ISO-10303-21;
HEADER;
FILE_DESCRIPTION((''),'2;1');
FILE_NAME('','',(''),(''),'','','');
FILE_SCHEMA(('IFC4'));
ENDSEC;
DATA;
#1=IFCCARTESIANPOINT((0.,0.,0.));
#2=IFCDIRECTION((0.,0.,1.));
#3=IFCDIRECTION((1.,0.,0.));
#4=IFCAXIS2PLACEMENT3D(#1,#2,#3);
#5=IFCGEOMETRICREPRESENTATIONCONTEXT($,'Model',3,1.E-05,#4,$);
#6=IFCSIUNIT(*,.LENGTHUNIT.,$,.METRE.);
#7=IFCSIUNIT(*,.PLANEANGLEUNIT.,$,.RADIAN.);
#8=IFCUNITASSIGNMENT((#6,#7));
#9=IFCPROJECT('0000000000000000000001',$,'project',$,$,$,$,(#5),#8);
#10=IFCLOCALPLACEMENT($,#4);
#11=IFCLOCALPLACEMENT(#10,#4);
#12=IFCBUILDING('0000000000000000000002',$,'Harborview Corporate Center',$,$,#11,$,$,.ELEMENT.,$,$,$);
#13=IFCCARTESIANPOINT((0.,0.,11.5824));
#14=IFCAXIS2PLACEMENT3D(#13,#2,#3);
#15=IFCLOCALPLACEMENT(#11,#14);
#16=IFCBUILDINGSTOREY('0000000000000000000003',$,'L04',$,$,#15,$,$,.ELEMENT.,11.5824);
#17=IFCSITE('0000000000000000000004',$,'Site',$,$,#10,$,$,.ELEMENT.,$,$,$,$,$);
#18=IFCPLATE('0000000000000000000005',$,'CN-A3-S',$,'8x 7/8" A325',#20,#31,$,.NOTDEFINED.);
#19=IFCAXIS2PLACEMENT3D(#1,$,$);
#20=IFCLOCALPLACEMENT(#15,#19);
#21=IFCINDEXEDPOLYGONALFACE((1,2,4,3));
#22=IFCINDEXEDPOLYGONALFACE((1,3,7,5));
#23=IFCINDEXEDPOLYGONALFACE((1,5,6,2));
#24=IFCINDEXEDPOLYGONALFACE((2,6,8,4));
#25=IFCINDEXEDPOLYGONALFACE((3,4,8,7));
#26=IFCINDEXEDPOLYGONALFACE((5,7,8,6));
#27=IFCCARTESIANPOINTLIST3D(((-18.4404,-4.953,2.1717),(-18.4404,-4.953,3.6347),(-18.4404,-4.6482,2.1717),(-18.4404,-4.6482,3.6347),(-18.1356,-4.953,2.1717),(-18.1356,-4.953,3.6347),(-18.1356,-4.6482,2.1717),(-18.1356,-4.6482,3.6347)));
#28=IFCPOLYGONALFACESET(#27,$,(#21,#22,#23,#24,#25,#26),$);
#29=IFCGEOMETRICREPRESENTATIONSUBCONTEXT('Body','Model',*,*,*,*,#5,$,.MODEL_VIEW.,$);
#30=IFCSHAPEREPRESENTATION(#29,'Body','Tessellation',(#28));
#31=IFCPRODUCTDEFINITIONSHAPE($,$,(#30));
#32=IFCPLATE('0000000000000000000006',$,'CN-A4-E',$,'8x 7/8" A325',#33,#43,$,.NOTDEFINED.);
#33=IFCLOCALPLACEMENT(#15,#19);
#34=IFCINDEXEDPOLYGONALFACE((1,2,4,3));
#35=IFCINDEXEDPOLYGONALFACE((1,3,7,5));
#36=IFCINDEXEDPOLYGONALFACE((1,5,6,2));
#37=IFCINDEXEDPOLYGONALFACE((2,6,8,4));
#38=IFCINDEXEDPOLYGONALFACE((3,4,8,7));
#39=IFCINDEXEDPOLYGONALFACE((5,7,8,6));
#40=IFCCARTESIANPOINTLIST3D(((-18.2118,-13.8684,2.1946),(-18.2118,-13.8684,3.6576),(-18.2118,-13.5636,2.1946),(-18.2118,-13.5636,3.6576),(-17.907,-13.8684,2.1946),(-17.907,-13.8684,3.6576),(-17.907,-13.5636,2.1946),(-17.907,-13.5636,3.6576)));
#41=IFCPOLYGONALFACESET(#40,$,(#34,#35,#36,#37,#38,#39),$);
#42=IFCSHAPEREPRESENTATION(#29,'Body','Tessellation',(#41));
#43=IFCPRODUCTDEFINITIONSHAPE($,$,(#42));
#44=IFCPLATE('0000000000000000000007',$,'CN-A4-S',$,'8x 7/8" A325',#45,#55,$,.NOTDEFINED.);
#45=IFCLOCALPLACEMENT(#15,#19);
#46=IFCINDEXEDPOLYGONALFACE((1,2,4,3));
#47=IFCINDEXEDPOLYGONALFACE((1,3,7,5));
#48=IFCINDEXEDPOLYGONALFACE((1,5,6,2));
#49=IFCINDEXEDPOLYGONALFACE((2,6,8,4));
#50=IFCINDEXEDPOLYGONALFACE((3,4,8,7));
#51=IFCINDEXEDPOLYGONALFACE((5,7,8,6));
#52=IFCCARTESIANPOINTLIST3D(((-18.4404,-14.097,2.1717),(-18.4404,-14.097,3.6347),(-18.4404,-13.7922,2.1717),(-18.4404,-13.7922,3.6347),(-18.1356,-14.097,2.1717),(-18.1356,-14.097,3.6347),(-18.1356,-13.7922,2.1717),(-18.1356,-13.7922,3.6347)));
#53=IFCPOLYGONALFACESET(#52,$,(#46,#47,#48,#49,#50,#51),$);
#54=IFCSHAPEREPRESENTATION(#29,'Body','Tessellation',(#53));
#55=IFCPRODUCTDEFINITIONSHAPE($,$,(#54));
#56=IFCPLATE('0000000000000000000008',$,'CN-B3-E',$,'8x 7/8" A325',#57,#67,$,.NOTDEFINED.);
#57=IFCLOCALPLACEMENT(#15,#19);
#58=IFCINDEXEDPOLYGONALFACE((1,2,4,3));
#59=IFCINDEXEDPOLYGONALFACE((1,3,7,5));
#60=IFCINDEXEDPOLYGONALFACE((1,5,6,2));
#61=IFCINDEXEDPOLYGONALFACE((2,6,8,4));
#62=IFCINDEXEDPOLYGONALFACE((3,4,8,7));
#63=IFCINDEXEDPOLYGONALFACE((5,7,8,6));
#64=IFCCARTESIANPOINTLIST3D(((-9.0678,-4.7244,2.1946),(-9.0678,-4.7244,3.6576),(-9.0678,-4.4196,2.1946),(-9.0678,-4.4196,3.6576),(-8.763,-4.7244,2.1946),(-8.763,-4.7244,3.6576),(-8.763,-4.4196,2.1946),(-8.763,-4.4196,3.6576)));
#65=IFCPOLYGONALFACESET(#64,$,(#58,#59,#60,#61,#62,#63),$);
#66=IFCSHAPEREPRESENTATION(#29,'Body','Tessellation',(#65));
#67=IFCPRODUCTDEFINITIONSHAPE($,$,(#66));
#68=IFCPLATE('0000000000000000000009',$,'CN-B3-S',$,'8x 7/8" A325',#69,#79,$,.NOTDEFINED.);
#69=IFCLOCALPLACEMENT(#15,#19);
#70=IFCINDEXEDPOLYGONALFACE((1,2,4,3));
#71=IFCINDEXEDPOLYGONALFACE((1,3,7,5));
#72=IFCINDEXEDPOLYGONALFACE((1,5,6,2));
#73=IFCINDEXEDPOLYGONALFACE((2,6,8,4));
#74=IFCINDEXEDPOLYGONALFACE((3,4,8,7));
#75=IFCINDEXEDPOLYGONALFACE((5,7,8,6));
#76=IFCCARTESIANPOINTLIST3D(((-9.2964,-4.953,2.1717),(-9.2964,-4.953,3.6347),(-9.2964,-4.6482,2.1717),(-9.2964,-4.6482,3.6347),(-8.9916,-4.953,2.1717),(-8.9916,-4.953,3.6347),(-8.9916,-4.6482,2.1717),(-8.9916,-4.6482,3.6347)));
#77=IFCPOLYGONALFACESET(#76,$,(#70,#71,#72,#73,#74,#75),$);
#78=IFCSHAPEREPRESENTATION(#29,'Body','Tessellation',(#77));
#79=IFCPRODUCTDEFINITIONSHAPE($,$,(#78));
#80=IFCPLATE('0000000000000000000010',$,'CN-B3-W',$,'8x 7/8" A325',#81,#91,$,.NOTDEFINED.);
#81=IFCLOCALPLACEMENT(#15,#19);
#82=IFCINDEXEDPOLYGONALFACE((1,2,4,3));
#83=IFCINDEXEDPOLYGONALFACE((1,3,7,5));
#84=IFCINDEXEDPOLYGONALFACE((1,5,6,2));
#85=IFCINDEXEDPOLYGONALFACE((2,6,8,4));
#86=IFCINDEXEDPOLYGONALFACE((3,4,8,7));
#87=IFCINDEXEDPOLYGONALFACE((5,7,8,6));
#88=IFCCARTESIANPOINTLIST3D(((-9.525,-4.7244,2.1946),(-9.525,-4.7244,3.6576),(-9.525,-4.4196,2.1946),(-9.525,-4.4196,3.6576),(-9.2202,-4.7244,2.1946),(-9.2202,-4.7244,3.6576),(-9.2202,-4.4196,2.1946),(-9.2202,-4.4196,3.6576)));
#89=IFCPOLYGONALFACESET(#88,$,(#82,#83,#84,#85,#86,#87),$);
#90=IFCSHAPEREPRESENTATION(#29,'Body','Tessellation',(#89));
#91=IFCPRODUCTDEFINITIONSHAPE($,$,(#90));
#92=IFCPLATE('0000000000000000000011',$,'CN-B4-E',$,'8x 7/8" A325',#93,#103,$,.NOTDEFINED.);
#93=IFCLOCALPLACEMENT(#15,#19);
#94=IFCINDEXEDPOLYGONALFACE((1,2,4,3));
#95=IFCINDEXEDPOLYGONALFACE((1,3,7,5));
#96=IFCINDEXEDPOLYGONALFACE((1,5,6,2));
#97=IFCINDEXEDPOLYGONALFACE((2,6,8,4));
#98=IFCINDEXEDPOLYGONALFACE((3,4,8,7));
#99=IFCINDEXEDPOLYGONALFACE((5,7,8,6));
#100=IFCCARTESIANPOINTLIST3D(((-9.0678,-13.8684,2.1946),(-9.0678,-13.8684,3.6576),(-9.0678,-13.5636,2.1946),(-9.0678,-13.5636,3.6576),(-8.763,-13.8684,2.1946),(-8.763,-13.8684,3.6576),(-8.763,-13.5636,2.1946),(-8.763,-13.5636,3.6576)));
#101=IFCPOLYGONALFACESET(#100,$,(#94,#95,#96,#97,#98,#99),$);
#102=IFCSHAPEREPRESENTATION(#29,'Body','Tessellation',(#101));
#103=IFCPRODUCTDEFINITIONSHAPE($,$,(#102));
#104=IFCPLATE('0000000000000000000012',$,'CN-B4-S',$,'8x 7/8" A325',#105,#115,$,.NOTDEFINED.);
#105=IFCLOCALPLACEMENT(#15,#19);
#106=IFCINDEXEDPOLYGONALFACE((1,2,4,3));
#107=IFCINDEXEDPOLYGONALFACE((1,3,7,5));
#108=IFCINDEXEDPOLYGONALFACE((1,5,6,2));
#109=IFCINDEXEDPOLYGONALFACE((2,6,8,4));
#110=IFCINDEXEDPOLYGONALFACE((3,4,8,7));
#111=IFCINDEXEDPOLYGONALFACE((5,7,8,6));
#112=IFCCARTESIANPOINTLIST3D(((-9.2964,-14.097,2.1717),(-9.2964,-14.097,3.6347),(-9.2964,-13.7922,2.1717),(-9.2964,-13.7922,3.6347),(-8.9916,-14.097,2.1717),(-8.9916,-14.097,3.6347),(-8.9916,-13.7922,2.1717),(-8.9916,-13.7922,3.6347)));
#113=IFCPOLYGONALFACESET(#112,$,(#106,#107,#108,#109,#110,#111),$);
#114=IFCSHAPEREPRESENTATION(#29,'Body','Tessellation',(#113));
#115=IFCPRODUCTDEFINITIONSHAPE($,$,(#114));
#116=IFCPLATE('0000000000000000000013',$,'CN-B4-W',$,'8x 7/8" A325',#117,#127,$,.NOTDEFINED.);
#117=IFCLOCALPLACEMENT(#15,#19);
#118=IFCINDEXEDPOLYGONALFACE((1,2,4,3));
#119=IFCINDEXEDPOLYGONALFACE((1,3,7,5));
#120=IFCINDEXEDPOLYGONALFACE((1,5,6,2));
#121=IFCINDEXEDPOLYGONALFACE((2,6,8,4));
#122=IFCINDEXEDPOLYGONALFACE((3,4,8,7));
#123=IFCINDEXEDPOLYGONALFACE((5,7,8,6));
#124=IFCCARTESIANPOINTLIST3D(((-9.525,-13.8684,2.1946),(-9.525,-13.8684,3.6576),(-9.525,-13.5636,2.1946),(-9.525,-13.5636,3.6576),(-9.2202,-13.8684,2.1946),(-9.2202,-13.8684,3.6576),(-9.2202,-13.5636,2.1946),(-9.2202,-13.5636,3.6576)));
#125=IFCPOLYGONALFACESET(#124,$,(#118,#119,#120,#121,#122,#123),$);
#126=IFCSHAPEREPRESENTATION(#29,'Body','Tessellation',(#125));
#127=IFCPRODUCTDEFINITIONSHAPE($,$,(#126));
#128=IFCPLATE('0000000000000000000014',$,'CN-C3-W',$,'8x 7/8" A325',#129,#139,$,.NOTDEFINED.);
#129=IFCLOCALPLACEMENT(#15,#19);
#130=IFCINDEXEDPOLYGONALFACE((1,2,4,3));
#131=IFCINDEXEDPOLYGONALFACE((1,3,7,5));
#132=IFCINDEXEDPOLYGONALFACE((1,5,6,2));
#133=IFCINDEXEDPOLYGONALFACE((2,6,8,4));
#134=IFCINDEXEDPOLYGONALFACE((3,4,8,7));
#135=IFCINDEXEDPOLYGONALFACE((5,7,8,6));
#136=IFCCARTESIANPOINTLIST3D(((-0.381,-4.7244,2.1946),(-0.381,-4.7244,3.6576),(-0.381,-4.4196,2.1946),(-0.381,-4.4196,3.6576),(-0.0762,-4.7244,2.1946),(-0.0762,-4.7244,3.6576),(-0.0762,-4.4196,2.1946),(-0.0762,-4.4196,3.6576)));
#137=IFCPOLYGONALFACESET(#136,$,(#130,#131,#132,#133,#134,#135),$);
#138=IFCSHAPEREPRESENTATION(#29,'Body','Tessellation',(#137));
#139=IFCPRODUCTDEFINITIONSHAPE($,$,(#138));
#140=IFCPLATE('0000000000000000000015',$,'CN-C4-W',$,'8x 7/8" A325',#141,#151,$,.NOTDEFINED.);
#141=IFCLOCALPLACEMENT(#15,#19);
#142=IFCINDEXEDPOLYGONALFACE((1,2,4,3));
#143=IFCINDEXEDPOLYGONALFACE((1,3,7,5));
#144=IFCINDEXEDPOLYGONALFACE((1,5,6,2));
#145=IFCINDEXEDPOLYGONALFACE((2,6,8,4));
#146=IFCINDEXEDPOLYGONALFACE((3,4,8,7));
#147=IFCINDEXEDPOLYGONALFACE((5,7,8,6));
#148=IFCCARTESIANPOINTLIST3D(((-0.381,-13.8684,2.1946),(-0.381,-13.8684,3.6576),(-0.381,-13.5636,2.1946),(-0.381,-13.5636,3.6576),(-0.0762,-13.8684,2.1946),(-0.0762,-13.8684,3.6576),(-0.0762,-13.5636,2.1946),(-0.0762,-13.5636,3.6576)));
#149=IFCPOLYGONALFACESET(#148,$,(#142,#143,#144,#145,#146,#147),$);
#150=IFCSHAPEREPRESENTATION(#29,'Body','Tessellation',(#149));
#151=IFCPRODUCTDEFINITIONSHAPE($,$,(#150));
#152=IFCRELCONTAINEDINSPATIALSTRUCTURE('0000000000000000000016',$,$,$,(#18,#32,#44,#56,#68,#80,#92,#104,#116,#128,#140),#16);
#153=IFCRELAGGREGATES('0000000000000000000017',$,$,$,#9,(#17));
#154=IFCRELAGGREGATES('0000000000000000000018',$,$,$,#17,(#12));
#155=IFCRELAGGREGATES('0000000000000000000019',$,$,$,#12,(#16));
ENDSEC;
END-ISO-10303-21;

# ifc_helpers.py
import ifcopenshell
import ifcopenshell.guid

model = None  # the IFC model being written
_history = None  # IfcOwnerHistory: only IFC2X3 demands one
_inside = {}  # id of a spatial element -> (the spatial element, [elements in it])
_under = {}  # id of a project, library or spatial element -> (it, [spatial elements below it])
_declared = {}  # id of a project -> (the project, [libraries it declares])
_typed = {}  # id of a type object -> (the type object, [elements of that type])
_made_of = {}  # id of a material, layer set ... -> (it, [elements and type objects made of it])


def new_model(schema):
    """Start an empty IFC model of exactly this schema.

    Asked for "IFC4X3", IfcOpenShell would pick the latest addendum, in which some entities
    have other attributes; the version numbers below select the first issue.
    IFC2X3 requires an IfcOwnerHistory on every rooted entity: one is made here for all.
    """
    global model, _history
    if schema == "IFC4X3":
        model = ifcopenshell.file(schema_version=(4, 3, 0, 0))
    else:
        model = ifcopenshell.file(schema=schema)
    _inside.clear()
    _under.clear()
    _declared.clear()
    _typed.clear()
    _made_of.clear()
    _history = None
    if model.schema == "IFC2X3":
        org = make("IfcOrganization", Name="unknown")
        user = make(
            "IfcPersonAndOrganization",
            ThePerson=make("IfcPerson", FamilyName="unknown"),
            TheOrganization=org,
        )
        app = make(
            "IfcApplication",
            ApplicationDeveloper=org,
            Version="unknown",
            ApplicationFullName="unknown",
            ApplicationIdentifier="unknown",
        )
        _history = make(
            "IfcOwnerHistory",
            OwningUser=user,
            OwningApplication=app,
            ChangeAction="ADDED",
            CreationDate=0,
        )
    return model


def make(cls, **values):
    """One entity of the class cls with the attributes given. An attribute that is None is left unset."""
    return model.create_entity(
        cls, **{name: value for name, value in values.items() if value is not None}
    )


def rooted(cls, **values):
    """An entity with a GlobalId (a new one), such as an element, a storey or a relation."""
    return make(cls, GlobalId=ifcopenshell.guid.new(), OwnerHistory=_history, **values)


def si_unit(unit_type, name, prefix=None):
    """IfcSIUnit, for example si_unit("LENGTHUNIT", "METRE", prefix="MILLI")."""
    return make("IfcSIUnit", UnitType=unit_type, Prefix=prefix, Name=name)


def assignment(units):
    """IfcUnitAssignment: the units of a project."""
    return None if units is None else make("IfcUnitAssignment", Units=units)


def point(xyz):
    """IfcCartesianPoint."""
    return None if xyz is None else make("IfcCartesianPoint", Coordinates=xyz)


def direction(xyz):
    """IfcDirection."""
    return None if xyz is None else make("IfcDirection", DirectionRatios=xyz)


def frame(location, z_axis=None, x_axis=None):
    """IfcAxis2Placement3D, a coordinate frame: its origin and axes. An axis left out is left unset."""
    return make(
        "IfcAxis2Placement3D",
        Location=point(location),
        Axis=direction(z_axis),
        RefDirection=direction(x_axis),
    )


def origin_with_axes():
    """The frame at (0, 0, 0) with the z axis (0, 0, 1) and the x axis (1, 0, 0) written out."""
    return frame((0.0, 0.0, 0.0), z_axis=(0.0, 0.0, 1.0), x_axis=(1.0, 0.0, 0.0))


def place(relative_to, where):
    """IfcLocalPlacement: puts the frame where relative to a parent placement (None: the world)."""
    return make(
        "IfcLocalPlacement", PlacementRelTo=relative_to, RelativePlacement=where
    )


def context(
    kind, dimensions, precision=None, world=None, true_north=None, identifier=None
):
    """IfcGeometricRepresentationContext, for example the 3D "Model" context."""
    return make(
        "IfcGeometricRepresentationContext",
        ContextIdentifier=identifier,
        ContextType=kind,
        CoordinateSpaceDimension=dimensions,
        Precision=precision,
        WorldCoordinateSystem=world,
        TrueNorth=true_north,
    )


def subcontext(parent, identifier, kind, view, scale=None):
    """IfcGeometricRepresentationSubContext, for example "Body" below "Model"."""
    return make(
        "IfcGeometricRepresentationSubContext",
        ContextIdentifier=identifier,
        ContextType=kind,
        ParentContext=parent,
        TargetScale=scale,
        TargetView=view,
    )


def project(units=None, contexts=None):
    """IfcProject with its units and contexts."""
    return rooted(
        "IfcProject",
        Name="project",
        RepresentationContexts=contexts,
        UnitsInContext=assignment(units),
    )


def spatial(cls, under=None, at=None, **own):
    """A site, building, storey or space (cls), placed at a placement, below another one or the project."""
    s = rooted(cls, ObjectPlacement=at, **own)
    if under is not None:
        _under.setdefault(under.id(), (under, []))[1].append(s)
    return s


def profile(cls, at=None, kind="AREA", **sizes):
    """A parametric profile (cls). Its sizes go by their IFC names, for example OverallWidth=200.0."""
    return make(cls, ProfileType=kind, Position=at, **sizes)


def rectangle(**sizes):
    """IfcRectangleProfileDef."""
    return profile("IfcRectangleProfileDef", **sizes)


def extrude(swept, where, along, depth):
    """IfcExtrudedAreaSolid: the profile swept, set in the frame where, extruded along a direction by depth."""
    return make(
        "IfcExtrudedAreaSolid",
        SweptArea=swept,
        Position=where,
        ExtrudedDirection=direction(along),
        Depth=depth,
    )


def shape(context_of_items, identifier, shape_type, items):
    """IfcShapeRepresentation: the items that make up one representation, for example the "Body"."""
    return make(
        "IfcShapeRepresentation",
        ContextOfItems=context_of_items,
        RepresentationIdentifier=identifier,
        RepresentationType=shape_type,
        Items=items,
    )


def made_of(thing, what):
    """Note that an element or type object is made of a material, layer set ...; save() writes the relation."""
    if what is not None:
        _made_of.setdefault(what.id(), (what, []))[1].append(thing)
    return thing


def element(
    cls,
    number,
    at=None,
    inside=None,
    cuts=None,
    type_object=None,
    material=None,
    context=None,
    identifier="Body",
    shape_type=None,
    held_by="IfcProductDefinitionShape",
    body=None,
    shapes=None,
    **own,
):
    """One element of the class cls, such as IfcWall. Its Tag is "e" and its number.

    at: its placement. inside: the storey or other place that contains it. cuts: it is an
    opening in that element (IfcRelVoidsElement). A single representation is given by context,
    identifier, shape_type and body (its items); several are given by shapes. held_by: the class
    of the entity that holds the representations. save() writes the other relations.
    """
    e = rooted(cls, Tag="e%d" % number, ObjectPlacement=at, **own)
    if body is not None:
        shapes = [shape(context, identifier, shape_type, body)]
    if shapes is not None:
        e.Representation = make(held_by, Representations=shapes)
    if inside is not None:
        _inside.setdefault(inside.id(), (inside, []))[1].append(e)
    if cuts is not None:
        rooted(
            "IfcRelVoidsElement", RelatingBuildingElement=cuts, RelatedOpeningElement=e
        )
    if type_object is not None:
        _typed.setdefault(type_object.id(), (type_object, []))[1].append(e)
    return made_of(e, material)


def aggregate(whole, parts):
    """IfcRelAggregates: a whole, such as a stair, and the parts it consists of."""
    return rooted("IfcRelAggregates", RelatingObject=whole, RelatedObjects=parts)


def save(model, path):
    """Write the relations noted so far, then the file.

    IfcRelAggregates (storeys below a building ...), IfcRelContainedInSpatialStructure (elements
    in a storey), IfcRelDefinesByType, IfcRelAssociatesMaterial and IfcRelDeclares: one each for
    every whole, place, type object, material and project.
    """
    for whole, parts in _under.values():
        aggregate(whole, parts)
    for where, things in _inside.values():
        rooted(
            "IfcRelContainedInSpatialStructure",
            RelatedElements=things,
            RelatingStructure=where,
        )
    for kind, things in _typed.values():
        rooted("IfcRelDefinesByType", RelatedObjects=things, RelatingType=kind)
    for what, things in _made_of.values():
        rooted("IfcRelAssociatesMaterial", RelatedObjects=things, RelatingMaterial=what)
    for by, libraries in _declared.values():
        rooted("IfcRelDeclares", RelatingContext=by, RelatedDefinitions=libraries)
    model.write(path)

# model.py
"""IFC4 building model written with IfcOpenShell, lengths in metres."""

from ifc_helpers import new_model, si_unit, frame, origin_with_axes, place, context, subcontext, project, spatial, rectangle, extrude, element, save


model = new_model("IFC4")

# Units and contexts
model_context = context("Model", 3, precision=1e-05, world=origin_with_axes())
body_context = subcontext(model_context, "Body", "Model", "MODEL_VIEW")
ifc_project = project(units=[si_unit("LENGTHUNIT", "METRE"), si_unit("PLANEANGLEUNIT", "RADIAN")], contexts=[model_context])

# Site, building, storey
site_placement = place(None, origin_with_axes())
site = spatial("IfcSite", under=ifc_project, at=site_placement, Name="Site", CompositionType="ELEMENT")
building_placement = place(site_placement, origin_with_axes())
building = spatial("IfcBuilding", under=site, at=building_placement, Name="Harborview Corporate Center", CompositionType="ELEMENT")
storey_placement = place(building_placement, frame((0.0, 0.0, 11.5824), z_axis=(0.0, 0.0, 1.0), x_axis=(1.0, 0.0, 0.0)))
storey = spatial("IfcBuildingStorey", under=building, at=storey_placement, Name="L04", CompositionType="ELEMENT", Elevation=11.5824)

# Plates
for number, where, z_axis, x_axis, name in (
    (1, (-18.288, -4.8006, 2.1717), (0.0, 0.0, 1.0), (1.0, 0.0, 0.0), "CN-A3-S"),
    (2, (-18.0594, -13.716, 2.1946), (0.0, 0.0, 1.0), (1.0, 0.0, 0.0), "CN-A4-E"),
    (3, (-18.288, -13.9446, 2.1717), (0.0, 0.0, 1.0), (1.0, 0.0, 0.0), "CN-A4-S"),
    (4, (-8.9154, -4.572, 2.1946), (0.0, 0.0, 1.0), (1.0, 0.0, 0.0), "CN-B3-E"),
    (5, (-9.144, -4.8006, 2.1717), (0.0, 0.0, 1.0), (1.0, 0.0, 0.0), "CN-B3-S"),
    (6, (-9.3726, -4.572, 2.1946), (0.0, 0.0, 1.0), (1.0, 0.0, 0.0), "CN-B3-W"),
    (7, (-8.9154, -13.716, 2.1946), (0.0, 0.0, 1.0), (1.0, 0.0, 0.0), "CN-B4-E"),
    (8, (-9.144, -13.9446, 2.1717), (0.0, 0.0, 1.0), (1.0, 0.0, 0.0), "CN-B4-S"),
    (9, (-9.3726, -13.716, 2.1946), (0.0, 0.0, 1.0), (1.0, 0.0, 0.0), "CN-B4-W"),
):
    element("IfcPlate", number, at=place(storey_placement, frame(where, z_axis=z_axis, x_axis=x_axis)), inside=storey, Name=name, ObjectType="8x 7/8\" A325", PredefinedType="NOTDEFINED", context=body_context, shape_type="SweptSolid", body=[
        extrude(rectangle(XDim=0.3048, YDim=0.3048), origin_with_axes(), (0.0, 0.0, 1.0), 1.463),
    ])
for number, where, z_axis, x_axis, name in (
    (10, (-0.2286, -4.572, 2.1946), (0.0, 0.0, 1.0), (1.0, 0.0, 0.0), "CN-C3-W"),
    (11, (-0.2286, -13.716, 2.1946), (0.0, 0.0, 1.0), (1.0, 0.0, 0.0), "CN-C4-W"),
):
    element("IfcPlate", number, at=place(storey_placement, frame(where, z_axis=z_axis, x_axis=x_axis)), inside=storey, Name=name, ObjectType="8x 7/8\" A325", PredefinedType="NOTDEFINED", context=body_context, shape_type="SweptSolid", body=[
        extrude(rectangle(XDim=0.3048, YDim=0.3048), origin_with_axes(), (0.0, 0.0, 1.0), 1.463),
    ])

save(model, "model.ifc")
